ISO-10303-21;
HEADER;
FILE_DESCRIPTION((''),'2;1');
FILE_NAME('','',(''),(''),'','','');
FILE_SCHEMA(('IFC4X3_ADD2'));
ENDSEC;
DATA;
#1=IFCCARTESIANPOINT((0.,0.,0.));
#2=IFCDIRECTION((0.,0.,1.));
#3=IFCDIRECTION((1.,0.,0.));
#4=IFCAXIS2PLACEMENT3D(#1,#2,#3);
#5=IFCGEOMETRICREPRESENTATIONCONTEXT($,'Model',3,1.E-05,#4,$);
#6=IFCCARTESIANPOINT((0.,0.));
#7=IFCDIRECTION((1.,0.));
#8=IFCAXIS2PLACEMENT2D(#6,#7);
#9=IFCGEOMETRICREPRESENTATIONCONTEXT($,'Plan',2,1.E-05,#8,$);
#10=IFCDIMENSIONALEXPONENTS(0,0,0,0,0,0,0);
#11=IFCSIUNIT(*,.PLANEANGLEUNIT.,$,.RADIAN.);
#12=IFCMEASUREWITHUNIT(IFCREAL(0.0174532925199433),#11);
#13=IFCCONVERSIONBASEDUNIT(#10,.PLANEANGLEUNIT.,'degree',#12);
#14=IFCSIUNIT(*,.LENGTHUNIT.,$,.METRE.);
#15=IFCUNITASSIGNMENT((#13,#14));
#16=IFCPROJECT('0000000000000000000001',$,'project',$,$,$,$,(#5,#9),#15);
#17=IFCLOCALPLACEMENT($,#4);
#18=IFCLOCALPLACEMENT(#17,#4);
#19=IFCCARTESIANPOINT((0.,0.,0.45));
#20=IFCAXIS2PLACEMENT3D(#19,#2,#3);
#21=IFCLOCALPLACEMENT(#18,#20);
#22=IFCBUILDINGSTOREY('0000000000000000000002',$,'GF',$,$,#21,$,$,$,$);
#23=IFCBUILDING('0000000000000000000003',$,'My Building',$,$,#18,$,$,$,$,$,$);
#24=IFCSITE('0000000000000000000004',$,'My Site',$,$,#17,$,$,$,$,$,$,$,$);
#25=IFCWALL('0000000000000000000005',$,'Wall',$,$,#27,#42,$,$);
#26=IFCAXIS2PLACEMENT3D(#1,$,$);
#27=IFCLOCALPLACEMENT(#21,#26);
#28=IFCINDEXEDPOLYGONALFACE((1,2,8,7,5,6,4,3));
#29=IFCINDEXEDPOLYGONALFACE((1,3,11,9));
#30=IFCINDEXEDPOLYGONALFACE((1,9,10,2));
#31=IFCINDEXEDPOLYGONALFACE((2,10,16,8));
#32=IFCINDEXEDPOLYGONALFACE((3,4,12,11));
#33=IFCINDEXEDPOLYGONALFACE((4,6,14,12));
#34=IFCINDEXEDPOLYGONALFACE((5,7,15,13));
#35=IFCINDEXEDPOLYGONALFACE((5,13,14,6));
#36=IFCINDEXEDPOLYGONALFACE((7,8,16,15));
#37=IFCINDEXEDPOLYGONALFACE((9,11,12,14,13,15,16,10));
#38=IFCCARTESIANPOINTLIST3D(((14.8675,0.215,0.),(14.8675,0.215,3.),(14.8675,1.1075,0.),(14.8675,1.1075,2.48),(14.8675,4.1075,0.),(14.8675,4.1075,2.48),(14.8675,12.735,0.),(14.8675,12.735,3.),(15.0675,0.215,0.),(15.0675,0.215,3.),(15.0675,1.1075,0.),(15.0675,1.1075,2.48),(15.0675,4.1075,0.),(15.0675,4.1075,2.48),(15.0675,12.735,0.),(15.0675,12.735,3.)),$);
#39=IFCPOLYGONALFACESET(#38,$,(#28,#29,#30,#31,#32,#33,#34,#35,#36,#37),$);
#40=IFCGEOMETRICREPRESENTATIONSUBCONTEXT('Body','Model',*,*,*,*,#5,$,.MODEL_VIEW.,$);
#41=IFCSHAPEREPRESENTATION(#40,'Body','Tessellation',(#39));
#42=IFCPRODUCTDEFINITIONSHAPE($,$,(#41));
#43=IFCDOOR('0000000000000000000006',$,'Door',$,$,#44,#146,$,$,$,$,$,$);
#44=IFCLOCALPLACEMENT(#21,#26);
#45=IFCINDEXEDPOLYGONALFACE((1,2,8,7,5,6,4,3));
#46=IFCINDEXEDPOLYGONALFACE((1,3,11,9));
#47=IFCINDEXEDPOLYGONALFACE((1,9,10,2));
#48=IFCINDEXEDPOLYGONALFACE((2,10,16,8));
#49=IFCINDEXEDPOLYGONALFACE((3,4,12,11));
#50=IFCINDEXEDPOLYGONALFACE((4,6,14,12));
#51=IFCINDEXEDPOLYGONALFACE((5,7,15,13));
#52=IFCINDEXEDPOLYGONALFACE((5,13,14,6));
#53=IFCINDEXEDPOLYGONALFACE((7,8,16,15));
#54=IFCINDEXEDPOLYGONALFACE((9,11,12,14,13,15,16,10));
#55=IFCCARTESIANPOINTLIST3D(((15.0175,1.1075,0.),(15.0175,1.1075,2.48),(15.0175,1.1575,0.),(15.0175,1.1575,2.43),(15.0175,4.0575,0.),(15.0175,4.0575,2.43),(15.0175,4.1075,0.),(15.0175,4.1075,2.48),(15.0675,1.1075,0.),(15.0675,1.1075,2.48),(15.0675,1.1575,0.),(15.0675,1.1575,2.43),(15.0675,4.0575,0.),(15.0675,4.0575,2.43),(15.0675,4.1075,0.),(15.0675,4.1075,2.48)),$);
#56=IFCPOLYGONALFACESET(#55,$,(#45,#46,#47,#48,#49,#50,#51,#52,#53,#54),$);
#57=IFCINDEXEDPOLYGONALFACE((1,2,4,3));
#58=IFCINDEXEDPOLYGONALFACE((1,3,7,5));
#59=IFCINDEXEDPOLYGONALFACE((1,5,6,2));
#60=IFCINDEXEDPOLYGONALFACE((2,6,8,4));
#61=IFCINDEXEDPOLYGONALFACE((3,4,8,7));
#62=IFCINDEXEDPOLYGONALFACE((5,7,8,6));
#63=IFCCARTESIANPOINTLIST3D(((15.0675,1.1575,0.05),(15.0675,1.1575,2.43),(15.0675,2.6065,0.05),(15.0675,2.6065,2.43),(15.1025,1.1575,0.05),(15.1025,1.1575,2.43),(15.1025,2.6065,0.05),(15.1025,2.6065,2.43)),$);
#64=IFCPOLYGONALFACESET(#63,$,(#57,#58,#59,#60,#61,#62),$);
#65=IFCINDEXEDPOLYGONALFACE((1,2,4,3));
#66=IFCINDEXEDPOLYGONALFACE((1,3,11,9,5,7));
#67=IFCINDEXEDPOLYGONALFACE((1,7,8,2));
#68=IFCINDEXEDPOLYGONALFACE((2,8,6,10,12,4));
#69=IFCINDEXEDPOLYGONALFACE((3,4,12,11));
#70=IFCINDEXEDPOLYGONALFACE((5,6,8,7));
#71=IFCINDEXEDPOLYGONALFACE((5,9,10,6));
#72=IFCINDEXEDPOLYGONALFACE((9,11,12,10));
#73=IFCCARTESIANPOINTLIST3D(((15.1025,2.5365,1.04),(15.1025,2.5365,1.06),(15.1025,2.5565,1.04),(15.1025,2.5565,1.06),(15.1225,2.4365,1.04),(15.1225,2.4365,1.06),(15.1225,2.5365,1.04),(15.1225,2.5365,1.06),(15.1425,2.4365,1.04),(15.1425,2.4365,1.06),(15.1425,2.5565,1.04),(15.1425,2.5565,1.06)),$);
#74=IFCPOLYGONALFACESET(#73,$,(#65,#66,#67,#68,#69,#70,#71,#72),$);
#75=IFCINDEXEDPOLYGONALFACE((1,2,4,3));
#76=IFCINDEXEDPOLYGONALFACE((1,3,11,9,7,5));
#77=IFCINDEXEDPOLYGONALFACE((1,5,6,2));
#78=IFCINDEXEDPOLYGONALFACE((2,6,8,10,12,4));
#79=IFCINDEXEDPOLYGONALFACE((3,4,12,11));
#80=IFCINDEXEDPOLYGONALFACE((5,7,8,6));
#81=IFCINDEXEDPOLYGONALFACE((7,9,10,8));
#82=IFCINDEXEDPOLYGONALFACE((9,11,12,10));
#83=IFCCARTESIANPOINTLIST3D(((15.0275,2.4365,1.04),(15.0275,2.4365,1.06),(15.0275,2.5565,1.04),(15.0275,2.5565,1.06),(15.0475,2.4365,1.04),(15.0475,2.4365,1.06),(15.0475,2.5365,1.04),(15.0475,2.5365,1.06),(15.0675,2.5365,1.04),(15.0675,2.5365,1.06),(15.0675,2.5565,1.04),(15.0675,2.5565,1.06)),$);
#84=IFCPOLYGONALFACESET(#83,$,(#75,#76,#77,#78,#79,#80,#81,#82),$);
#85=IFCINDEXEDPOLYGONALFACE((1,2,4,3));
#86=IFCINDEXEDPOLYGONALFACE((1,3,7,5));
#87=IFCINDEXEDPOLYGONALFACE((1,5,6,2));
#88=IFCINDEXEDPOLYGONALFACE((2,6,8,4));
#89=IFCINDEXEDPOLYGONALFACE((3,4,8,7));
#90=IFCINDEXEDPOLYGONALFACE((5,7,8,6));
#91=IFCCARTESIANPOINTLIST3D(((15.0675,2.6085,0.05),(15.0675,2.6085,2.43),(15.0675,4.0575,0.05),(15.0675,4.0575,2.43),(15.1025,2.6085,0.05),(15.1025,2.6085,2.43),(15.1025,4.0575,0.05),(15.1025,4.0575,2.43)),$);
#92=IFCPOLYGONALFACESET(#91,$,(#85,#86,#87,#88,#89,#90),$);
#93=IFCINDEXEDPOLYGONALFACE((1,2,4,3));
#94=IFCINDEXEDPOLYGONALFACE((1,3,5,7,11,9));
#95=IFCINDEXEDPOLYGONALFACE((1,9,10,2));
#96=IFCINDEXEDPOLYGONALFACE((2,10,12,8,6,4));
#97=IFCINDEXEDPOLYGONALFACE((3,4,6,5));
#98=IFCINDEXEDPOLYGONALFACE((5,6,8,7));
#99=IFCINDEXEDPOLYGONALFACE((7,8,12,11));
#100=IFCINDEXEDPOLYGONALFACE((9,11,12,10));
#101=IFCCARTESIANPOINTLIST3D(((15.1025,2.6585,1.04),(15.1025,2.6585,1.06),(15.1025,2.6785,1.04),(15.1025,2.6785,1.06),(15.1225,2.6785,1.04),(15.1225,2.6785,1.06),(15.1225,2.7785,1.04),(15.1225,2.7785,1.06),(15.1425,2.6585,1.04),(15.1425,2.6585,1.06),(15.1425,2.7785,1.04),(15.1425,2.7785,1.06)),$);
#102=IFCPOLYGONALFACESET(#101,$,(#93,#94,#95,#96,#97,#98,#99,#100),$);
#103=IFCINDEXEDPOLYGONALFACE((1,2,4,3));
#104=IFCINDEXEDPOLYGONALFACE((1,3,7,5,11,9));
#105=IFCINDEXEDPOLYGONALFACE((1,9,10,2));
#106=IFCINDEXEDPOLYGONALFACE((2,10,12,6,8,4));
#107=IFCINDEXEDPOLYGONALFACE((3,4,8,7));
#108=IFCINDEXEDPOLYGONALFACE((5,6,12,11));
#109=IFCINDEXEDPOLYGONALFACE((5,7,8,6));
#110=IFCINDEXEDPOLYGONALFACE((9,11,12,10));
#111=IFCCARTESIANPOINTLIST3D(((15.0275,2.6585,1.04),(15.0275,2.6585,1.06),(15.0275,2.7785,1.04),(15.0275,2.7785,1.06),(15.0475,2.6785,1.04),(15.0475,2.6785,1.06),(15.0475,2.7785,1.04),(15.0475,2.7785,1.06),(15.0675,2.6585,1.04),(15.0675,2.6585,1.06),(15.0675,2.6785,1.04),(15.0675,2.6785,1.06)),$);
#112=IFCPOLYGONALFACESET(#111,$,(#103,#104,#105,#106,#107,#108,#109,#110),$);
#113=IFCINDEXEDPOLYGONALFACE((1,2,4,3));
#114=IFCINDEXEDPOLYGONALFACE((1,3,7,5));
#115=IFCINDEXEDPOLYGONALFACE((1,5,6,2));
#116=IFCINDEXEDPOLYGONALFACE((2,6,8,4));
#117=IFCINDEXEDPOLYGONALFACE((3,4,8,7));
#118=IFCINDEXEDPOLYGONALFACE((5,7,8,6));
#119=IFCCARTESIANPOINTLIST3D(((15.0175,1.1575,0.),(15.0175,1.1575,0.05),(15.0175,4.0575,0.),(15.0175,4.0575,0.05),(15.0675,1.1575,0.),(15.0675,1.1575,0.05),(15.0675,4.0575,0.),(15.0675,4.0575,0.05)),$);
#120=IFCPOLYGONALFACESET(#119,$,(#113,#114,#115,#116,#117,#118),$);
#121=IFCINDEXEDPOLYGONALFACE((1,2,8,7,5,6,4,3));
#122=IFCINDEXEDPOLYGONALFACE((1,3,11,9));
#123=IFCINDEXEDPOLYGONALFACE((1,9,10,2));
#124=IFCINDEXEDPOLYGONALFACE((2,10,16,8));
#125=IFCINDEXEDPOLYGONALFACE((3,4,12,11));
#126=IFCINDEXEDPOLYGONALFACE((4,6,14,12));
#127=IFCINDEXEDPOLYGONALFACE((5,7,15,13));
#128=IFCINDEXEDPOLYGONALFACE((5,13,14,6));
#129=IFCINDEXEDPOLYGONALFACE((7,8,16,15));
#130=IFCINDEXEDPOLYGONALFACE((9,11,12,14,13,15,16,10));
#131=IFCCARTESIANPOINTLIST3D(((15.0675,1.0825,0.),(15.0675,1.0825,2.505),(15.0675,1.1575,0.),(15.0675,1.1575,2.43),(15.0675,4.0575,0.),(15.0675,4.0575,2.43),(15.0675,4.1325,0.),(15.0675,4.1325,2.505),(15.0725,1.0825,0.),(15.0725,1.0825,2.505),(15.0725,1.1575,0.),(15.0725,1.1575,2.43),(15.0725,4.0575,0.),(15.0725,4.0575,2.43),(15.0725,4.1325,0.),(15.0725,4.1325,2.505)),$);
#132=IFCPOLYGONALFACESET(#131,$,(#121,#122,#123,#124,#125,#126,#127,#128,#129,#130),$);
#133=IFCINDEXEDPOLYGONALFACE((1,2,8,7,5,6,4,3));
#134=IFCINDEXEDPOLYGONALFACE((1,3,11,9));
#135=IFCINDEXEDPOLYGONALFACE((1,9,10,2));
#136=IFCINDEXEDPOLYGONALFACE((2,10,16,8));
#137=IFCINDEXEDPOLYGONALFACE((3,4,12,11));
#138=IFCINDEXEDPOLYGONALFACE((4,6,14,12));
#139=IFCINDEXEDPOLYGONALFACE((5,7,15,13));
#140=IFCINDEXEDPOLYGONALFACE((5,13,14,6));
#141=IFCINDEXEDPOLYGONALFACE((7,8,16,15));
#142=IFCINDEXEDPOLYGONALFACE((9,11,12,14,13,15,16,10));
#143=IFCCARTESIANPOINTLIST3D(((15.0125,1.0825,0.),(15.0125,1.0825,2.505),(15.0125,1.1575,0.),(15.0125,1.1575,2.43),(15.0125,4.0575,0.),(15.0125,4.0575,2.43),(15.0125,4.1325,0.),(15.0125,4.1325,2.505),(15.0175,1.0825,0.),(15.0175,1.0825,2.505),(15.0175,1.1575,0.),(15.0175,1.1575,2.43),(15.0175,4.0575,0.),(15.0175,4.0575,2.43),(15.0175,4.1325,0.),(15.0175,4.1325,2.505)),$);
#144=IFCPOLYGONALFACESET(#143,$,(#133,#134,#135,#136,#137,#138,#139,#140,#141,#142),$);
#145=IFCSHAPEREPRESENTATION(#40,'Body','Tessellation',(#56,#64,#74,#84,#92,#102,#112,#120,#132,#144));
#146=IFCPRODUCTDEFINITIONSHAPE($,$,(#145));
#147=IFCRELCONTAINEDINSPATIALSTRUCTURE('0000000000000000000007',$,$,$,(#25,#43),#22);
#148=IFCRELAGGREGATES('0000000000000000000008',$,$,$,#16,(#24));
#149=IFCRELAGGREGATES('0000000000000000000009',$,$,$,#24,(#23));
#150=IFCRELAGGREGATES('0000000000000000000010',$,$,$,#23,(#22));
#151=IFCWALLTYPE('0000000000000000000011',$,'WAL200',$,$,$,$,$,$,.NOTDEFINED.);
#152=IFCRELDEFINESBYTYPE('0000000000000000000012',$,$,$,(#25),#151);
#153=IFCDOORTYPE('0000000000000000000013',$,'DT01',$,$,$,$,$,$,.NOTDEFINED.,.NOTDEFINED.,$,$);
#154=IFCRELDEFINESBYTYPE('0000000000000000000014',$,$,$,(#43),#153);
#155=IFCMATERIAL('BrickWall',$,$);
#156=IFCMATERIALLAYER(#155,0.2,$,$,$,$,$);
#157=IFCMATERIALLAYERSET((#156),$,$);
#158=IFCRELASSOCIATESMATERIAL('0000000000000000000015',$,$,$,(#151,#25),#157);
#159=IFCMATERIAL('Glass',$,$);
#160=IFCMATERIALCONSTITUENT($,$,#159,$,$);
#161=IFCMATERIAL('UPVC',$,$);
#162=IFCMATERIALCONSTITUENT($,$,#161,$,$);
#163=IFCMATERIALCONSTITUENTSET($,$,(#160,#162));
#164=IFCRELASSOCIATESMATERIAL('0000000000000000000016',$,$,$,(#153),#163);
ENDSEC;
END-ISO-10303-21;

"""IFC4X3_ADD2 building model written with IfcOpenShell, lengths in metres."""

from ifc_helpers import new_model, entity, si_unit, converted_unit, frame, origin_with_axes, origin_2d_with_axis, place, context, subcontext, project, spatial, line, indexed_curve, outline, extrude, shape, source, transform, mapped, material, layer, layer_set, layer_usage, constituent, constituent_set, type_object, type_shapes, element, fill, save


model = new_model("IFC4X3_ADD2")

# Units and contexts
model_context = context("Model", 3, precision=1e-05, world=origin_with_axes())
plan_context = context("Plan", 2, precision=1e-05, world=origin_2d_with_axis())
body_context_1 = subcontext(model_context, "Body", "Model", "MODEL_VIEW")
body_context_2 = subcontext(plan_context, "Body", "Plan", "PLAN_VIEW")
ifc_project = project(units=[converted_unit("PLANEANGLEUNIT", "degree", entity("IfcReal", 0.0174532925199433), si_unit("PLANEANGLEUNIT", "RADIAN"), dimensions=[0, 0, 0, 0, 0, 0, 0]), si_unit("LENGTHUNIT", "METRE")], contexts=[model_context, plan_context])

# Site, building, storey
site_placement = place(None, origin_with_axes())
site = spatial("IfcSite", under=ifc_project, at=site_placement, Name="My Site")
building_placement = place(site_placement, origin_with_axes())
building = spatial("IfcBuilding", under=site, at=building_placement, Name="My Building")
storey_placement = place(building_placement, frame((0.0, 0.0, 0.45), z_axis=(0.0, 0.0, 1.0), x_axis=(1.0, 0.0, 0.0)))
storey = spatial("IfcBuildingStorey", under=building, at=storey_placement, Name="GF")

# Shared definitions
ifc_material_1 = material(Name="BrickWall")
ifc_layer_1 = layer(ifc_material_1, 0.2)
ifc_layer_set_1 = layer_set([ifc_layer_1])
wall_type_1 = type_object("IfcWallType", Name="WAL200", PredefinedType="NOTDEFINED", material=ifc_layer_set_1)
shared_shape_1 = source(origin_with_axes(), body_context_1, "Body", "SweptSolid", [
    extrude(outline(indexed_curve([(0.0, 0.0), (3.0, 0.0), (3.0, 2.48), (0.0, 2.48)], segments=[line(1, 2, 3, 4, 1)])), frame((0.0, -0.6, 0.0), z_axis=(0.0, -1.0, 0.0), x_axis=(1.0, 0.0, 0.0)), (0.0, 0.0, -1.0), 1.2),
])
ifc_material_2 = material(Name="Glass")
ifc_constituent_1 = constituent(ifc_material_2)
ifc_material_3 = material(Name="UPVC")
ifc_constituent_2 = constituent(ifc_material_3)
ifc_constituent_set = constituent_set(constituents=[ifc_constituent_1, ifc_constituent_2])
door_type_1 = type_object("IfcDoorType", Name="DT01", OperationType="NOTDEFINED", PredefinedType="NOTDEFINED", material=ifc_constituent_set)
shared_shape_2 = source(origin_with_axes(), body_context_1, "Body", "SweptSolid", [
    extrude(outline(indexed_curve([(3.0, 0.0), (3.0, 2.48), (0.0, 2.48), (0.0, 0.0), (0.05, 0.0), (0.05, 2.43), (2.95, 2.43), (2.95, 0.0)], segments=[line(5, 4), line(4, 3), line(3, 2), line(2, 1), line(1, 8), line(8, 7), line(7, 6), line(6, 5)], self_intersect=False)), frame((0.0, 0.0, 0.0), z_axis=(0.0, -1.0, 0.0), x_axis=(1.0, 0.0, 0.0)), (0.0, 0.0, -1.0), 0.05),
    extrude(outline(indexed_curve([(0.0, 0.0), (1.449, 0.0), (1.449, 0.035), (0.0, 0.035)], segments=[line(1, 2, 3, 4, 1)])), frame((0.05, -0.035, 0.05), z_axis=(0.0, 0.0, 1.0), x_axis=(1.0, 0.0, 0.0)), (0.0, 0.0, 1.0), 2.38),
    extrude(outline(indexed_curve([(0.0, 0.0), (0.0, -0.04), (-0.12, -0.04), (-0.12, -0.02), (-0.02, -0.02), (-0.02, 0.0)], segments=[line(1, 2, 3, 4, 5, 6, 1)])), frame((1.449, -0.035, 1.04), z_axis=(0.0, 0.0, 1.0), x_axis=(1.0, 0.0, 0.0)), (0.0, 0.0, 1.0), 0.02),
    extrude(outline(indexed_curve([(0.0, 0.0), (0.0, 0.04), (-0.12, 0.04), (-0.12, 0.02), (-0.02, 0.02), (-0.02, 0.0)], segments=[line(1, 2, 3, 4, 5, 6, 1)])), frame((1.449, 0.0, 1.04), z_axis=(0.0, 0.0, 1.0), x_axis=(1.0, 0.0, 0.0)), (0.0, 0.0, 1.0), 0.02),
    extrude(outline(indexed_curve([(0.0, 0.0), (-1.449, 0.0), (-1.449, 0.035), (0.0, 0.035)], segments=[line(1, 2, 3, 4, 1)])), frame((2.95, -0.035, 0.05), z_axis=(0.0, 0.0, 1.0), x_axis=(1.0, 0.0, 0.0)), (0.0, 0.0, 1.0), 2.38),
    extrude(outline(indexed_curve([(0.0, 0.0), (0.0, -0.04), (0.12, -0.04), (0.12, -0.02), (0.02, -0.02), (0.02, 0.0)], segments=[line(1, 2, 3, 4, 5, 6, 1)])), frame((1.551, -0.035, 1.04), z_axis=(0.0, 0.0, 1.0), x_axis=(1.0, 0.0, 0.0)), (0.0, 0.0, 1.0), 0.02),
    extrude(outline(indexed_curve([(0.0, 0.0), (0.0, 0.04), (0.12, 0.04), (0.12, 0.02), (0.02, 0.02), (0.02, 0.0)], segments=[line(1, 2, 3, 4, 5, 6, 1)])), frame((1.551, 0.0, 1.04), z_axis=(0.0, 0.0, 1.0), x_axis=(1.0, 0.0, 0.0)), (0.0, 0.0, 1.0), 0.02),
    extrude(outline(indexed_curve([(0.0, 0.0), (2.9, 0.0), (2.9, 0.05), (0.0, 0.05)], segments=[line(1, 2, 3, 4, 1)])), frame((0.05, 0.0, 0.0), z_axis=(0.0, 0.0, 1.0), x_axis=(1.0, 0.0, 0.0)), (0.0, 0.0, 1.0), 0.05),
    extrude(outline(indexed_curve([(0.0, 0.0), (0.0, 2.505), (3.05, 2.505), (3.05, 0.0), (2.975, 0.0), (2.975, 2.43), (0.075, 2.43), (0.075, 0.0)], segments=[line(1, 2, 3, 4, 5, 6, 7, 8, 1)])), frame((-0.025, -0.005, 0.0), z_axis=(0.0, -1.0, 0.0), x_axis=(1.0, 0.0, 0.0)), (0.0, 0.0, -1.0), 0.005),
    extrude(outline(indexed_curve([(0.0, 0.0), (0.0, 2.505), (3.05, 2.505), (3.05, 0.0), (2.975, 0.0), (2.975, 2.43), (0.075, 2.43), (0.075, 0.0)], segments=[line(1, 2, 3, 4, 5, 6, 7, 8, 1)])), frame((-0.025, 0.05, 0.0), z_axis=(0.0, -1.0, 0.0), x_axis=(1.0, 0.0, 0.0)), (0.0, 0.0, -1.0), 0.005),
])
shared_shape_3 = source(origin_with_axes(), body_context_2, "Body", "Curve2D", [
    entity("IfcIndexedPolyCurve", entity("IfcCartesianPointList2D", [[0.0, 0.0], [0.05, 0.0], [0.05, 0.05], [0.0, 0.05]]), [entity("IfcLineIndex", [1, 2, 3, 4, 1])]),
    entity("IfcIndexedPolyCurve", entity("IfcCartesianPointList2D", [[3.0, 0.0], [2.95, 0.0], [2.95, 0.05], [3.0, 0.05]]), [entity("IfcLineIndex", [1, 2, 3, 4, 1])]),
    entity("IfcIndexedPolyCurve", entity("IfcCartesianPointList2D", [[-0.675, -0.035], [0.775, -0.035], [0.775, 0.0], [-0.675, 0.0]]), [entity("IfcLineIndex", [1, 2, 3, 4, 1])]),
    entity("IfcIndexedPolyCurve", entity("IfcCartesianPointList2D", [[3.675, -0.035], [2.225, -0.035], [2.225, 0.0], [3.675, 0.0]]), [entity("IfcLineIndex", [1, 2, 3, 4, 1])]),
])
type_shapes(door_type_1, [shared_shape_2, shared_shape_3])

# Wall, opening, door
ifc_layer_usage_1 = layer_usage(ifc_layer_set_1, "AXIS2", "POSITIVE", 0.0)
wall_1_placement = place(storey_placement, frame((15.0675, 0.215, 0.0), z_axis=(0.0, 0.0, 1.0), x_axis=(0.0, 1.0, 0.0)))
wall_1 = element("IfcWall", 1, at=wall_1_placement, inside=storey, type_object=wall_type_1, material=ifc_layer_usage_1, Name="Wall", context=body_context_1, shape_type="SweptSolid", body=[
    extrude(outline(indexed_curve([(0.0, 0.0), (0.0, 0.2), (12.52, 0.2), (12.52, 0.0), (0.0, 0.0)], self_intersect=False)), origin_with_axes(), (0.0, 0.0, 1.0), 3.0),
])
opening_1_placement = place(wall_1_placement, frame((0.8925, 0.0, 0.0), z_axis=(0.0, 0.0, 1.0), x_axis=(1.0, 0.0, 0.0)))
opening_1 = element("IfcOpeningElement", 2, at=opening_1_placement, cuts=wall_1, PredefinedType="OPENING", context=body_context_1, shape_type="MappedRepresentation", body=[
    mapped(shared_shape_1, transform((0.0, 0.0, 0.0), x_axis=(1.0, 0.0, 0.0), y_axis=(0.0, 1.0, 0.0), z_axis=(0.0, 0.0, 1.0), scale=1.0)),
])
door_1_placement = place(opening_1_placement, origin_with_axes())
door_1 = element("IfcDoor", 3, at=door_1_placement, inside=storey, type_object=door_type_1, Name="Door", shapes=[
    shape(body_context_1, "Body", "MappedRepresentation", [mapped(shared_shape_2, transform((0.0, 0.0, 0.0), x_axis=(1.0, 0.0, 0.0), y_axis=(0.0, 1.0, 0.0), z_axis=(0.0, 0.0, 1.0), scale=1.0))]),
    shape(body_context_2, "Body", "MappedRepresentation", [mapped(shared_shape_3, transform((0.0, 0.0, 0.0), x_axis=(1.0, 0.0, 0.0), y_axis=(0.0, 1.0, 0.0), z_axis=(0.0, 0.0, 1.0), scale=1.0))]),
])
fill(opening_1, door_1)

save(model, "model.ifc")
